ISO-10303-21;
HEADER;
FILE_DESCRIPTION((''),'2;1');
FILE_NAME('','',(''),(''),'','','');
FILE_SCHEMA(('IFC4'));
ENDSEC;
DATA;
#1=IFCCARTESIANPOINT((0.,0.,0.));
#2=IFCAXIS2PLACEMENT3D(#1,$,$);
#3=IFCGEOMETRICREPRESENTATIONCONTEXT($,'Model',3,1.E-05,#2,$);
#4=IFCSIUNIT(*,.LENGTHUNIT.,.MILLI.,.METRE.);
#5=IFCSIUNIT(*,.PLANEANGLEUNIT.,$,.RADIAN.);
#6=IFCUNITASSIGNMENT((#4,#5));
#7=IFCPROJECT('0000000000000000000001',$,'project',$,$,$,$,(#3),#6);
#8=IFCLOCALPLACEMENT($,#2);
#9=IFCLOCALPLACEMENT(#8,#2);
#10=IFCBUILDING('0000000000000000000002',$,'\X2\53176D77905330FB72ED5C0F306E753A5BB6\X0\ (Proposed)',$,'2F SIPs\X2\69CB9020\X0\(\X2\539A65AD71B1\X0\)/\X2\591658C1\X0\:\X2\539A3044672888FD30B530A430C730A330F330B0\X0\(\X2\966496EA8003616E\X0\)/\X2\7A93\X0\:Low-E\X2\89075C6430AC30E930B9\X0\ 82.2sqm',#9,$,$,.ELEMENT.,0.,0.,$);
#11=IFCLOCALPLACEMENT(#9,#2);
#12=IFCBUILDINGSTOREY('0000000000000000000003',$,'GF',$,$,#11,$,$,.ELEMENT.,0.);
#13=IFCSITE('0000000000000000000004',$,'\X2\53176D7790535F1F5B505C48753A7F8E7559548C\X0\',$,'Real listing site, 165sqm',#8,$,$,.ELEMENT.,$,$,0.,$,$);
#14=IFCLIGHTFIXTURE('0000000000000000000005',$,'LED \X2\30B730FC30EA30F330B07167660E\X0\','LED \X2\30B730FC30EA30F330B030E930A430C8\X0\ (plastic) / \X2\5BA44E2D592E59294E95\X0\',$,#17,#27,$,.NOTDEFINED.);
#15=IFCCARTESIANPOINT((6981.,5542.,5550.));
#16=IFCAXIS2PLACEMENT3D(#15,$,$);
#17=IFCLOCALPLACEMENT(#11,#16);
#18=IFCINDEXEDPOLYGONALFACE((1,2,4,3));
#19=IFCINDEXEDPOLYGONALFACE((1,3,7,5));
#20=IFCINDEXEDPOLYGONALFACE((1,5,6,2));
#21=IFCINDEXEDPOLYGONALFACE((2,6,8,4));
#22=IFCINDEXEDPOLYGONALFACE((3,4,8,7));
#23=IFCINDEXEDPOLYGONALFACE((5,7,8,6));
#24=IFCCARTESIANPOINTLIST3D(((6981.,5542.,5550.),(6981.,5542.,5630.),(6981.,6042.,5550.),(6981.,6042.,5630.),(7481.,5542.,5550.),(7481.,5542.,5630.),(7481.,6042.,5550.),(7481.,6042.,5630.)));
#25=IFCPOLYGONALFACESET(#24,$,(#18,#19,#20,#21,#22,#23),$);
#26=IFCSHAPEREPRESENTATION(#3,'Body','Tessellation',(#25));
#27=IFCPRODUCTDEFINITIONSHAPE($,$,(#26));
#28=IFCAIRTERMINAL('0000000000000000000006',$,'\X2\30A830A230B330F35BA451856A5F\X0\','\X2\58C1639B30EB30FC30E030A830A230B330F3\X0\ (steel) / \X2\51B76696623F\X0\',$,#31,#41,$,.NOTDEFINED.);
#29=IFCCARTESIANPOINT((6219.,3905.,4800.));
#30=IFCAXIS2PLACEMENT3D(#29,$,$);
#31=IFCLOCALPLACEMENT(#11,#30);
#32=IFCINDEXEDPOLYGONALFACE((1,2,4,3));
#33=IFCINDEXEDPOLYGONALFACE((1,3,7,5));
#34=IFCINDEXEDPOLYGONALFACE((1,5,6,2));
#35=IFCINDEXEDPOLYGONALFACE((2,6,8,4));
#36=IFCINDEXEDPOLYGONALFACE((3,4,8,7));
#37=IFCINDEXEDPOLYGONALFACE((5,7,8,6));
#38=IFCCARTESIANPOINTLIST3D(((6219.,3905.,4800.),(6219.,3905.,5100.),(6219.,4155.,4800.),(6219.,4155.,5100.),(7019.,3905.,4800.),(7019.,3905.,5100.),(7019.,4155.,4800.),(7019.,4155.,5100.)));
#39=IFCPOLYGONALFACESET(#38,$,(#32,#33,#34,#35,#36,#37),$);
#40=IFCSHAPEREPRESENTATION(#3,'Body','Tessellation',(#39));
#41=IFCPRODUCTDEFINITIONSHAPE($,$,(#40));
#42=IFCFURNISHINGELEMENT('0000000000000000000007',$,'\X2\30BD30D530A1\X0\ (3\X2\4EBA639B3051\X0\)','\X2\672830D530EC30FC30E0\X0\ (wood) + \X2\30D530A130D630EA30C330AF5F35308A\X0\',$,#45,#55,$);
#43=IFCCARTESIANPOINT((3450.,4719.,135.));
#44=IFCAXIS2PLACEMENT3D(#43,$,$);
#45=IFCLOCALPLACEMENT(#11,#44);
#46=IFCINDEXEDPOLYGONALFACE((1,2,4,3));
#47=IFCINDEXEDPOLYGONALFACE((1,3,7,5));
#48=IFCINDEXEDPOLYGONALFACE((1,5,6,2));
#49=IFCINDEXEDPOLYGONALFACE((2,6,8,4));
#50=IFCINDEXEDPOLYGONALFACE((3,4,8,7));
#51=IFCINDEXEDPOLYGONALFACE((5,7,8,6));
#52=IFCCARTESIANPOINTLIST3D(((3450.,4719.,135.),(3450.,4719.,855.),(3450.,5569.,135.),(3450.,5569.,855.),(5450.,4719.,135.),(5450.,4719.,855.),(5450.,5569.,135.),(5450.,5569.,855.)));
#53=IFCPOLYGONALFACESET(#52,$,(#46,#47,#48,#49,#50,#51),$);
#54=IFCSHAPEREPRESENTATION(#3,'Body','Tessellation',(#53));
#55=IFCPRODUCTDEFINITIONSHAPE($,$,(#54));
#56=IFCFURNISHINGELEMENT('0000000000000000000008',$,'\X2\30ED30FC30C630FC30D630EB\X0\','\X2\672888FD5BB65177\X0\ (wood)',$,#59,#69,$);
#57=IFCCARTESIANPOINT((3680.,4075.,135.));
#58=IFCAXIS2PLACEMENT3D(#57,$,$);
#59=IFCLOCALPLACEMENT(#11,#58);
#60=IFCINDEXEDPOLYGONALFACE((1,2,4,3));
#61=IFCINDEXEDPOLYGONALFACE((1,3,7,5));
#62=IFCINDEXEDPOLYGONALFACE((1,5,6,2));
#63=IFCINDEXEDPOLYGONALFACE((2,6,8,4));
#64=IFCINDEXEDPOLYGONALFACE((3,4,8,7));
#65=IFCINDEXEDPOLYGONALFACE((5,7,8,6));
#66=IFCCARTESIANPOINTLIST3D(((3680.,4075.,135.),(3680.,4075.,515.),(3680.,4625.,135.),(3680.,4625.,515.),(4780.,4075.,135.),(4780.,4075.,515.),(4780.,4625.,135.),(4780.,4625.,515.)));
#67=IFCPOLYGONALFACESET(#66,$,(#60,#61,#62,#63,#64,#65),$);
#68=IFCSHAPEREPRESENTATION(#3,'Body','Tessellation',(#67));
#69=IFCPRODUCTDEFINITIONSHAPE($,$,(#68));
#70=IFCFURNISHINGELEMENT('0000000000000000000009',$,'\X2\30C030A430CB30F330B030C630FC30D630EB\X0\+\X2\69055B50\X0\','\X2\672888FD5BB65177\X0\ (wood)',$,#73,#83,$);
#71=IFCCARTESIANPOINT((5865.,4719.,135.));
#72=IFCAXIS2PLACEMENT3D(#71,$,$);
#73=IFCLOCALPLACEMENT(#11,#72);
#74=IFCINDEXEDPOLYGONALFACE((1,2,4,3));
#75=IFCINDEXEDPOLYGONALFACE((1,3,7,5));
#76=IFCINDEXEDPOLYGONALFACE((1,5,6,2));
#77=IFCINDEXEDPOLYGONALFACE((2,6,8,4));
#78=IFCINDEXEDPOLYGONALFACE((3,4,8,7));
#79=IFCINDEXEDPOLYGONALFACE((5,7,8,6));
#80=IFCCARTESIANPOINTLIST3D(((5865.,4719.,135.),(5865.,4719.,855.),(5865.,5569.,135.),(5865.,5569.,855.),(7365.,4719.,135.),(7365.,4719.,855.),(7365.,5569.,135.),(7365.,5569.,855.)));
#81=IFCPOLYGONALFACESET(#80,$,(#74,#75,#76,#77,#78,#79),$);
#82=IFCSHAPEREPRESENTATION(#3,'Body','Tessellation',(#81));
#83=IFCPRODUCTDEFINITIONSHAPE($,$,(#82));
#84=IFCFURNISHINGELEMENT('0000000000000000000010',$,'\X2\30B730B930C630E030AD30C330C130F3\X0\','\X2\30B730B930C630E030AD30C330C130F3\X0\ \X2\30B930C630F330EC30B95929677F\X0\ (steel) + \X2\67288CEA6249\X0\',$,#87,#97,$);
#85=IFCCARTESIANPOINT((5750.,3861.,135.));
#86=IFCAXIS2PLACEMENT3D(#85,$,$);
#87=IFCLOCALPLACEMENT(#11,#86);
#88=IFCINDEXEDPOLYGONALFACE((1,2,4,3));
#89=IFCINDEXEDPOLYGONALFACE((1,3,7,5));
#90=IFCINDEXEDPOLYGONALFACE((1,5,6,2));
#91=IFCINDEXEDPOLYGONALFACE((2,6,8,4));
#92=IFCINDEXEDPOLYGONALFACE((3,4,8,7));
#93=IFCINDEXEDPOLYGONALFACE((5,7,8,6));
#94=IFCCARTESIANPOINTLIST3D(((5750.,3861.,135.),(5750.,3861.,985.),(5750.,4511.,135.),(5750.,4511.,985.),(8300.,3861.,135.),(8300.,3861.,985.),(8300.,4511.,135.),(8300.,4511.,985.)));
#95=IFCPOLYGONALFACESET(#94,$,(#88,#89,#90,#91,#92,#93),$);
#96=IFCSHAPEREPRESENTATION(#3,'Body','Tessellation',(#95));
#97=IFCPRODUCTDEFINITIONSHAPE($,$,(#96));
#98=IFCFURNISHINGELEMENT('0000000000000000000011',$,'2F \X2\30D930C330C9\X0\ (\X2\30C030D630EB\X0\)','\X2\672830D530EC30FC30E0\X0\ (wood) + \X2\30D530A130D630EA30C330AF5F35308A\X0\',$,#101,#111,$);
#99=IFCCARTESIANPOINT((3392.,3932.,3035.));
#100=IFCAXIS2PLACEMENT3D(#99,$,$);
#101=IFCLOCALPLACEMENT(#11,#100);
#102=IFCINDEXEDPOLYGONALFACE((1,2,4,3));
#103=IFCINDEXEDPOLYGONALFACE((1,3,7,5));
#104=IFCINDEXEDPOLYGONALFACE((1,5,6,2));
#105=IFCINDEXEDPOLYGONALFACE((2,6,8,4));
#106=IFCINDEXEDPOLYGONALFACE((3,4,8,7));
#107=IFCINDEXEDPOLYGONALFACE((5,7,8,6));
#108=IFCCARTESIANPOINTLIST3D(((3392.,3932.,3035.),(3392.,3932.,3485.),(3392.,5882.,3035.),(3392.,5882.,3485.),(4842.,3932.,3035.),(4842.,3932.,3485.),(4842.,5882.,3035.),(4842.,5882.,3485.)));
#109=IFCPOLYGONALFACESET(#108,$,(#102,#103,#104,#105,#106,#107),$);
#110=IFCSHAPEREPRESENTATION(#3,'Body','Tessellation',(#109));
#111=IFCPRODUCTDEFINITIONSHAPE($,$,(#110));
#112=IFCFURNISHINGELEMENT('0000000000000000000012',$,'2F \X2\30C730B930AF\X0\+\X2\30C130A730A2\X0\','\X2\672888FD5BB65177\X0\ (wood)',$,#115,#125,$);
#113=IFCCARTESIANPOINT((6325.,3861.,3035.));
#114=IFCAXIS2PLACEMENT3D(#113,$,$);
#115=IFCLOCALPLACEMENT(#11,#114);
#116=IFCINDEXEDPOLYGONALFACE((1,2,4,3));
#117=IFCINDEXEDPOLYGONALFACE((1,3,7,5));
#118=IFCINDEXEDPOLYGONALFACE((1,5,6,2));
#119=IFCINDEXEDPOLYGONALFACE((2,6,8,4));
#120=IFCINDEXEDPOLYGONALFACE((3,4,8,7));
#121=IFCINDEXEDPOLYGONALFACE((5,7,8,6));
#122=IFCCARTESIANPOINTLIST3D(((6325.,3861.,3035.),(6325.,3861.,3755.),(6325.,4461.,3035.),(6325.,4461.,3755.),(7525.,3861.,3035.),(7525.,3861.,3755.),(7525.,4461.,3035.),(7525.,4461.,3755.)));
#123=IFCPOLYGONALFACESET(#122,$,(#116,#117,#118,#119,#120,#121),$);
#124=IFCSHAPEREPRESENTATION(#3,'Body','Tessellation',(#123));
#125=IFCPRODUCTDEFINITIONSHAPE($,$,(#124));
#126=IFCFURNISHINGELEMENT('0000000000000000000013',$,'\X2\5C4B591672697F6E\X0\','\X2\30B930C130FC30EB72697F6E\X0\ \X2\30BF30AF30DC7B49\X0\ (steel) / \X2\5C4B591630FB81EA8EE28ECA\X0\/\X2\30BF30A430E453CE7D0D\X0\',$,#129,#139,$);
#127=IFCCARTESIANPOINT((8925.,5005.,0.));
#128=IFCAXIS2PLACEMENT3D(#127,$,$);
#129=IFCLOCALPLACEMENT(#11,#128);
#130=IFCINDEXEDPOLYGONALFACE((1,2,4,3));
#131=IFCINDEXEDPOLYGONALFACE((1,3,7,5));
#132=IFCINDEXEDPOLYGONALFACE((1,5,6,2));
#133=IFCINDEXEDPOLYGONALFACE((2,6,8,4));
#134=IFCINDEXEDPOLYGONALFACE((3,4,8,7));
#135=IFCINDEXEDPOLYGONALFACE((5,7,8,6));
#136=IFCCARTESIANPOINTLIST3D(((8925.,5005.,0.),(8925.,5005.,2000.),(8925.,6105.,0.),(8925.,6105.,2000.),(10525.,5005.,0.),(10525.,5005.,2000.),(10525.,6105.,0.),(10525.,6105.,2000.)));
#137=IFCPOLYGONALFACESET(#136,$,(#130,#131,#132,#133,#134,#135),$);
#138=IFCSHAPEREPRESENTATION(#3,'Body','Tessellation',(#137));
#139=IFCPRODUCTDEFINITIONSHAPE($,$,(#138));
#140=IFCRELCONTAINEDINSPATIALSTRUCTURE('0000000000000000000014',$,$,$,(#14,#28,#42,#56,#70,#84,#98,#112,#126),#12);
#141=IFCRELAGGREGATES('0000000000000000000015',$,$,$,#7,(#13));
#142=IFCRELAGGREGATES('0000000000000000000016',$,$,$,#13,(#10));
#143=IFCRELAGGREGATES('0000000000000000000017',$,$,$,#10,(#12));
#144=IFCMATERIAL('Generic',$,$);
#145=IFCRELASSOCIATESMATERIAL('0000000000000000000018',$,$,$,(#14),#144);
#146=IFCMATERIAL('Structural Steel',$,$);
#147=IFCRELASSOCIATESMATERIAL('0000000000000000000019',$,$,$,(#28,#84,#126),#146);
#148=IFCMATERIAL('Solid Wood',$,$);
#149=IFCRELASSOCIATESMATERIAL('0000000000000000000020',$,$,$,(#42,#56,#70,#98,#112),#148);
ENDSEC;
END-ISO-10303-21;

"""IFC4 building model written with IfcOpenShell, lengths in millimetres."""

from ifc_helpers import new_model, si_unit, frame, frame_2d, origin, place, context, project, spatial, rectangle, extrude, material, element, save


model = new_model("IFC4")

# Units and contexts
model_context = context("Model", 3, precision=1e-05, world=origin())
ifc_project = project(units=[si_unit("LENGTHUNIT", "METRE", prefix="MILLI"), si_unit("PLANEANGLEUNIT", "RADIAN")], contexts=[model_context])

# Site, building, storey
site_placement = place(None, origin())
site = spatial("IfcSite", under=ifc_project, at=site_placement, Name="北海道弟子屈町美留和", ObjectType="Real listing site, 165sqm", CompositionType="ELEMENT", RefElevation=0.0)
building_placement = place(site_placement, origin())
building = spatial("IfcBuilding", under=site, at=building_placement, Name="北海道・狭小の町家 (Proposed)", ObjectType="2F SIPs構造(厚断熱)/外壁:厚い木製サイディング(除雪考慮)/窓:Low-E複層ガラス 82.2sqm", CompositionType="ELEMENT", ElevationOfRefHeight=0.0, ElevationOfTerrain=0.0)
storey_placement = place(building_placement, origin())
storey = spatial("IfcBuildingStorey", under=building, at=storey_placement, Name="GF", CompositionType="ELEMENT", Elevation=0.0)

# Shared definitions
ifc_material_1 = material(Name="Solid Wood")

# Shared definitions
ifc_material_2 = material(Name="Generic")

# Shared definitions
ifc_material_3 = material(Name="Structural Steel")

# Light fixture
light_fixture_placement = place(storey_placement, frame((6981.0, 5542.0, 5550.0)))
element("IfcLightFixture", 1, at=light_fixture_placement, inside=storey, material=ifc_material_2, Name="LED シーリング照明", Description="LED シーリングライト (plastic) / 室中央天井", PredefinedType="NOTDEFINED", context=model_context, shape_type="SweptSolid", body=[
    extrude(rectangle(XDim=500.0, YDim=500.0, at=frame_2d((250.0, 250.0))), frame((6981.0, 5542.0, 5550.0)), (0.0, 0.0, 1.0), 80.0),
])

# Air terminal
air_terminal_1_placement = place(storey_placement, frame((6219.0, 3905.0, 4800.0)))
element("IfcAirTerminal", 2, at=air_terminal_1_placement, inside=storey, material=ifc_material_3, Name="エアコン室内機", Description="壁掛ルームエアコン (steel) / 冷暖房", PredefinedType="NOTDEFINED", context=model_context, shape_type="SweptSolid", body=[
    extrude(rectangle(XDim=800.0, YDim=250.0, at=frame_2d((400.0, 125.0))), frame((6219.0, 3905.0, 4800.0)), (0.0, 0.0, 1.0), 300.0),
])

# Furnishing elements
furnishing_1_placement = place(storey_placement, frame((3450.0, 4719.0, 135.0)))
element("IfcFurnishingElement", 3, at=furnishing_1_placement, inside=storey, material=ifc_material_1, Name="ソファ (3人掛け)", Description="木フレーム (wood) + ファブリック張り", context=model_context, shape_type="SweptSolid", body=[
    extrude(rectangle(XDim=2000.0, YDim=850.0, at=frame_2d((1000.0, 425.0))), frame((3450.0, 4719.0, 135.0)), (0.0, 0.0, 1.0), 720.0),
])
furnishing_2_placement = place(storey_placement, frame((3680.0, 4075.0, 135.0)))
element("IfcFurnishingElement", 4, at=furnishing_2_placement, inside=storey, material=ifc_material_1, Name="ローテーブル", Description="木製家具 (wood)", context=model_context, shape_type="SweptSolid", body=[
    extrude(rectangle(XDim=1100.0, YDim=550.0, at=frame_2d((550.0, 275.0))), frame((3680.0, 4075.0, 135.0)), (0.0, 0.0, 1.0), 380.0),
])
furnishing_3_placement = place(storey_placement, frame((5865.0, 4719.0, 135.0)))
element("IfcFurnishingElement", 5, at=furnishing_3_placement, inside=storey, material=ifc_material_1, Name="ダイニングテーブル+椅子", Description="木製家具 (wood)", context=model_context, shape_type="SweptSolid", body=[
    extrude(rectangle(XDim=1500.0, YDim=850.0, at=frame_2d((750.0, 425.0))), frame((5865.0, 4719.0, 135.0)), (0.0, 0.0, 1.0), 720.0),
])
furnishing_4_placement = place(storey_placement, frame((5750.0, 3861.0, 135.0)))
element("IfcFurnishingElement", 6, at=furnishing_4_placement, inside=storey, material=ifc_material_3, Name="システムキッチン", Description="システムキッチン ステンレス天板 (steel) + 木質扉", context=model_context, shape_type="SweptSolid", body=[
    extrude(rectangle(XDim=2550.0, YDim=650.0, at=frame_2d((1275.0, 325.0))), frame((5750.0, 3861.0, 135.0)), (0.0, 0.0, 1.0), 850.0),
])
furnishing_5_placement = place(storey_placement, frame((3392.0, 3932.0, 3035.0)))
element("IfcFurnishingElement", 7, at=furnishing_5_placement, inside=storey, material=ifc_material_1, Name="2F ベッド (ダブル)", Description="木フレーム (wood) + ファブリック張り", context=model_context, shape_type="SweptSolid", body=[
    extrude(rectangle(XDim=1450.0, YDim=1950.0, at=frame_2d((725.0, 975.0))), frame((3392.0, 3932.0, 3035.0)), (0.0, 0.0, 1.0), 450.0),
])
furnishing_6_placement = place(storey_placement, frame((6325.0, 3861.0, 3035.0)))
element("IfcFurnishingElement", 8, at=furnishing_6_placement, inside=storey, material=ifc_material_1, Name="2F デスク+チェア", Description="木製家具 (wood)", context=model_context, shape_type="SweptSolid", body=[
    extrude(rectangle(XDim=1200.0, YDim=600.0, at=frame_2d((600.0, 300.0))), frame((6325.0, 3861.0, 3035.0)), (0.0, 0.0, 1.0), 720.0),
])
furnishing_7_placement = place(storey_placement, frame((8925.0, 5005.0, 0.0)))
element("IfcFurnishingElement", 9, at=furnishing_7_placement, inside=storey, material=ifc_material_3, Name="屋外物置", Description="スチール物置 タクボ等 (steel) / 屋外・自転車/タイヤ収納", context=model_context, shape_type="SweptSolid", body=[
    extrude(rectangle(XDim=1600.0, YDim=1100.0, at=frame_2d((800.0, 550.0))), frame((8925.0, 5005.0, 0.0)), (0.0, 0.0, 1.0), 2000.0),
])

save(model, "model.ifc")
